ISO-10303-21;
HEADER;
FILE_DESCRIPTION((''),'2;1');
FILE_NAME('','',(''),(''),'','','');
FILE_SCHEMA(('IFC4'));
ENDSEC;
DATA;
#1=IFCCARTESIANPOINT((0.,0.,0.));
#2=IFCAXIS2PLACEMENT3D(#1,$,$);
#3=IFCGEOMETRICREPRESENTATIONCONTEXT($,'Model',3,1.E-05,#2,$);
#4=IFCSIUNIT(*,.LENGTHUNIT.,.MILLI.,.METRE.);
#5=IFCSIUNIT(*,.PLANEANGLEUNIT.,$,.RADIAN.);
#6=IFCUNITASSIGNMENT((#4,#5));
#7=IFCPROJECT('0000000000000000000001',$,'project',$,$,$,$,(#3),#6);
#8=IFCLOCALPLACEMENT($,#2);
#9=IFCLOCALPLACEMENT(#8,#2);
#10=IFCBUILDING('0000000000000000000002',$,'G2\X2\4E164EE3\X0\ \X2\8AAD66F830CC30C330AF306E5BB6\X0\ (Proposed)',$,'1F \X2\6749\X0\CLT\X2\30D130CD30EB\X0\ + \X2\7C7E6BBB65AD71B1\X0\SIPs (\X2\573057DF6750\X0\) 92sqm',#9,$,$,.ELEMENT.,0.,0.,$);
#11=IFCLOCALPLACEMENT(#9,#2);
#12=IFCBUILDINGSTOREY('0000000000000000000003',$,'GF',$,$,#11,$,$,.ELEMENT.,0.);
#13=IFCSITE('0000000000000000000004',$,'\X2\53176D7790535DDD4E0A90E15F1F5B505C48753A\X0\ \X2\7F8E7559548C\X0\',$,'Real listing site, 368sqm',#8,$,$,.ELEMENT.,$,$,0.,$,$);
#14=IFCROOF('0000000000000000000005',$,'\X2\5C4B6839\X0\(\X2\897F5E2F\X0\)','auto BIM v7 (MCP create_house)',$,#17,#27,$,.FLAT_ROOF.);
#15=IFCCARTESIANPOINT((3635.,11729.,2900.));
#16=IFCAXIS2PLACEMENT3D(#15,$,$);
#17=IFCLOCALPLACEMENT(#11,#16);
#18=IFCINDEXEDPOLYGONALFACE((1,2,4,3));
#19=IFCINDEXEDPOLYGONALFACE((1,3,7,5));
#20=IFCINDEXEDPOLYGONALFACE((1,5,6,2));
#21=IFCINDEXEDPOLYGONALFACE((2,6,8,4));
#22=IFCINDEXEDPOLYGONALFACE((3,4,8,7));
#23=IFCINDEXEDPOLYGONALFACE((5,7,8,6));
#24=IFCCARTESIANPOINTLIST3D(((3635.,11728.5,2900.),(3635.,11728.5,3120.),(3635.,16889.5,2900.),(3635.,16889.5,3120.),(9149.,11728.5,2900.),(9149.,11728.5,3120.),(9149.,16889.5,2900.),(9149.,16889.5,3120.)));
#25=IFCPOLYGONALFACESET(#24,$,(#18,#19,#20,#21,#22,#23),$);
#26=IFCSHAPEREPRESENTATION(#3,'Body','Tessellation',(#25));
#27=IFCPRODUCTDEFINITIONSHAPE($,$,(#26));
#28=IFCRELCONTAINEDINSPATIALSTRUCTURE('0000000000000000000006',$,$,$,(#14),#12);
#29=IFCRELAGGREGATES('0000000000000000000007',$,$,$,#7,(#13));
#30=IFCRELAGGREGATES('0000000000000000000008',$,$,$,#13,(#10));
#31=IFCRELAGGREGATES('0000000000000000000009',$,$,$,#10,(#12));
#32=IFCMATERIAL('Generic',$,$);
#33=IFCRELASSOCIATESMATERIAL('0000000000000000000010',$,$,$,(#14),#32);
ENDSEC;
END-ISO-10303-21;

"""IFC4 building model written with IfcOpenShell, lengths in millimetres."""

from ifc_helpers import new_model, si_unit, frame, frame_2d, origin, place, context, project, spatial, rectangle, extrude, material, element, save


model = new_model("IFC4")

# Units and contexts
model_context = context("Model", 3, precision=1e-05, world=origin())
ifc_project = project(units=[si_unit("LENGTHUNIT", "METRE", prefix="MILLI"), si_unit("PLANEANGLEUNIT", "RADIAN")], contexts=[model_context])

# Site, building, storey
site_placement = place(None, origin())
site = spatial("IfcSite", under=ifc_project, at=site_placement, Name="北海道川上郡弟子屈町 美留和", ObjectType="Real listing site, 368sqm", CompositionType="ELEMENT", RefElevation=0.0)
building_placement = place(site_placement, origin())
building = spatial("IfcBuilding", under=site, at=building_placement, Name="G2世代 読書ヌックの家 (Proposed)", ObjectType="1F 杉CLTパネル + 籾殻断熱SIPs (地域材) 92sqm", CompositionType="ELEMENT", ElevationOfRefHeight=0.0, ElevationOfTerrain=0.0)
storey_placement = place(building_placement, origin())
storey = spatial("IfcBuildingStorey", under=building, at=storey_placement, Name="GF", CompositionType="ELEMENT", Elevation=0.0)

# Shared definitions
ifc_material = material(Name="Generic")

# Roof
roof_1_placement = place(storey_placement, frame((3635.0, 11729.0, 2900.0)))
element("IfcRoof", 1, at=roof_1_placement, inside=storey, material=ifc_material, Name="屋根(西帯)", Description="auto BIM v7 (MCP create_house)", PredefinedType="FLAT_ROOF", context=model_context, shape_type="SweptSolid", body=[
    extrude(rectangle(XDim=5514.0, YDim=5161.0, at=frame_2d((2757.0, 2580.0))), frame((3635.0, 11729.0, 2900.0)), (0.0, 0.0, 1.0), 220.0),
])

save(model, "model.ifc")
